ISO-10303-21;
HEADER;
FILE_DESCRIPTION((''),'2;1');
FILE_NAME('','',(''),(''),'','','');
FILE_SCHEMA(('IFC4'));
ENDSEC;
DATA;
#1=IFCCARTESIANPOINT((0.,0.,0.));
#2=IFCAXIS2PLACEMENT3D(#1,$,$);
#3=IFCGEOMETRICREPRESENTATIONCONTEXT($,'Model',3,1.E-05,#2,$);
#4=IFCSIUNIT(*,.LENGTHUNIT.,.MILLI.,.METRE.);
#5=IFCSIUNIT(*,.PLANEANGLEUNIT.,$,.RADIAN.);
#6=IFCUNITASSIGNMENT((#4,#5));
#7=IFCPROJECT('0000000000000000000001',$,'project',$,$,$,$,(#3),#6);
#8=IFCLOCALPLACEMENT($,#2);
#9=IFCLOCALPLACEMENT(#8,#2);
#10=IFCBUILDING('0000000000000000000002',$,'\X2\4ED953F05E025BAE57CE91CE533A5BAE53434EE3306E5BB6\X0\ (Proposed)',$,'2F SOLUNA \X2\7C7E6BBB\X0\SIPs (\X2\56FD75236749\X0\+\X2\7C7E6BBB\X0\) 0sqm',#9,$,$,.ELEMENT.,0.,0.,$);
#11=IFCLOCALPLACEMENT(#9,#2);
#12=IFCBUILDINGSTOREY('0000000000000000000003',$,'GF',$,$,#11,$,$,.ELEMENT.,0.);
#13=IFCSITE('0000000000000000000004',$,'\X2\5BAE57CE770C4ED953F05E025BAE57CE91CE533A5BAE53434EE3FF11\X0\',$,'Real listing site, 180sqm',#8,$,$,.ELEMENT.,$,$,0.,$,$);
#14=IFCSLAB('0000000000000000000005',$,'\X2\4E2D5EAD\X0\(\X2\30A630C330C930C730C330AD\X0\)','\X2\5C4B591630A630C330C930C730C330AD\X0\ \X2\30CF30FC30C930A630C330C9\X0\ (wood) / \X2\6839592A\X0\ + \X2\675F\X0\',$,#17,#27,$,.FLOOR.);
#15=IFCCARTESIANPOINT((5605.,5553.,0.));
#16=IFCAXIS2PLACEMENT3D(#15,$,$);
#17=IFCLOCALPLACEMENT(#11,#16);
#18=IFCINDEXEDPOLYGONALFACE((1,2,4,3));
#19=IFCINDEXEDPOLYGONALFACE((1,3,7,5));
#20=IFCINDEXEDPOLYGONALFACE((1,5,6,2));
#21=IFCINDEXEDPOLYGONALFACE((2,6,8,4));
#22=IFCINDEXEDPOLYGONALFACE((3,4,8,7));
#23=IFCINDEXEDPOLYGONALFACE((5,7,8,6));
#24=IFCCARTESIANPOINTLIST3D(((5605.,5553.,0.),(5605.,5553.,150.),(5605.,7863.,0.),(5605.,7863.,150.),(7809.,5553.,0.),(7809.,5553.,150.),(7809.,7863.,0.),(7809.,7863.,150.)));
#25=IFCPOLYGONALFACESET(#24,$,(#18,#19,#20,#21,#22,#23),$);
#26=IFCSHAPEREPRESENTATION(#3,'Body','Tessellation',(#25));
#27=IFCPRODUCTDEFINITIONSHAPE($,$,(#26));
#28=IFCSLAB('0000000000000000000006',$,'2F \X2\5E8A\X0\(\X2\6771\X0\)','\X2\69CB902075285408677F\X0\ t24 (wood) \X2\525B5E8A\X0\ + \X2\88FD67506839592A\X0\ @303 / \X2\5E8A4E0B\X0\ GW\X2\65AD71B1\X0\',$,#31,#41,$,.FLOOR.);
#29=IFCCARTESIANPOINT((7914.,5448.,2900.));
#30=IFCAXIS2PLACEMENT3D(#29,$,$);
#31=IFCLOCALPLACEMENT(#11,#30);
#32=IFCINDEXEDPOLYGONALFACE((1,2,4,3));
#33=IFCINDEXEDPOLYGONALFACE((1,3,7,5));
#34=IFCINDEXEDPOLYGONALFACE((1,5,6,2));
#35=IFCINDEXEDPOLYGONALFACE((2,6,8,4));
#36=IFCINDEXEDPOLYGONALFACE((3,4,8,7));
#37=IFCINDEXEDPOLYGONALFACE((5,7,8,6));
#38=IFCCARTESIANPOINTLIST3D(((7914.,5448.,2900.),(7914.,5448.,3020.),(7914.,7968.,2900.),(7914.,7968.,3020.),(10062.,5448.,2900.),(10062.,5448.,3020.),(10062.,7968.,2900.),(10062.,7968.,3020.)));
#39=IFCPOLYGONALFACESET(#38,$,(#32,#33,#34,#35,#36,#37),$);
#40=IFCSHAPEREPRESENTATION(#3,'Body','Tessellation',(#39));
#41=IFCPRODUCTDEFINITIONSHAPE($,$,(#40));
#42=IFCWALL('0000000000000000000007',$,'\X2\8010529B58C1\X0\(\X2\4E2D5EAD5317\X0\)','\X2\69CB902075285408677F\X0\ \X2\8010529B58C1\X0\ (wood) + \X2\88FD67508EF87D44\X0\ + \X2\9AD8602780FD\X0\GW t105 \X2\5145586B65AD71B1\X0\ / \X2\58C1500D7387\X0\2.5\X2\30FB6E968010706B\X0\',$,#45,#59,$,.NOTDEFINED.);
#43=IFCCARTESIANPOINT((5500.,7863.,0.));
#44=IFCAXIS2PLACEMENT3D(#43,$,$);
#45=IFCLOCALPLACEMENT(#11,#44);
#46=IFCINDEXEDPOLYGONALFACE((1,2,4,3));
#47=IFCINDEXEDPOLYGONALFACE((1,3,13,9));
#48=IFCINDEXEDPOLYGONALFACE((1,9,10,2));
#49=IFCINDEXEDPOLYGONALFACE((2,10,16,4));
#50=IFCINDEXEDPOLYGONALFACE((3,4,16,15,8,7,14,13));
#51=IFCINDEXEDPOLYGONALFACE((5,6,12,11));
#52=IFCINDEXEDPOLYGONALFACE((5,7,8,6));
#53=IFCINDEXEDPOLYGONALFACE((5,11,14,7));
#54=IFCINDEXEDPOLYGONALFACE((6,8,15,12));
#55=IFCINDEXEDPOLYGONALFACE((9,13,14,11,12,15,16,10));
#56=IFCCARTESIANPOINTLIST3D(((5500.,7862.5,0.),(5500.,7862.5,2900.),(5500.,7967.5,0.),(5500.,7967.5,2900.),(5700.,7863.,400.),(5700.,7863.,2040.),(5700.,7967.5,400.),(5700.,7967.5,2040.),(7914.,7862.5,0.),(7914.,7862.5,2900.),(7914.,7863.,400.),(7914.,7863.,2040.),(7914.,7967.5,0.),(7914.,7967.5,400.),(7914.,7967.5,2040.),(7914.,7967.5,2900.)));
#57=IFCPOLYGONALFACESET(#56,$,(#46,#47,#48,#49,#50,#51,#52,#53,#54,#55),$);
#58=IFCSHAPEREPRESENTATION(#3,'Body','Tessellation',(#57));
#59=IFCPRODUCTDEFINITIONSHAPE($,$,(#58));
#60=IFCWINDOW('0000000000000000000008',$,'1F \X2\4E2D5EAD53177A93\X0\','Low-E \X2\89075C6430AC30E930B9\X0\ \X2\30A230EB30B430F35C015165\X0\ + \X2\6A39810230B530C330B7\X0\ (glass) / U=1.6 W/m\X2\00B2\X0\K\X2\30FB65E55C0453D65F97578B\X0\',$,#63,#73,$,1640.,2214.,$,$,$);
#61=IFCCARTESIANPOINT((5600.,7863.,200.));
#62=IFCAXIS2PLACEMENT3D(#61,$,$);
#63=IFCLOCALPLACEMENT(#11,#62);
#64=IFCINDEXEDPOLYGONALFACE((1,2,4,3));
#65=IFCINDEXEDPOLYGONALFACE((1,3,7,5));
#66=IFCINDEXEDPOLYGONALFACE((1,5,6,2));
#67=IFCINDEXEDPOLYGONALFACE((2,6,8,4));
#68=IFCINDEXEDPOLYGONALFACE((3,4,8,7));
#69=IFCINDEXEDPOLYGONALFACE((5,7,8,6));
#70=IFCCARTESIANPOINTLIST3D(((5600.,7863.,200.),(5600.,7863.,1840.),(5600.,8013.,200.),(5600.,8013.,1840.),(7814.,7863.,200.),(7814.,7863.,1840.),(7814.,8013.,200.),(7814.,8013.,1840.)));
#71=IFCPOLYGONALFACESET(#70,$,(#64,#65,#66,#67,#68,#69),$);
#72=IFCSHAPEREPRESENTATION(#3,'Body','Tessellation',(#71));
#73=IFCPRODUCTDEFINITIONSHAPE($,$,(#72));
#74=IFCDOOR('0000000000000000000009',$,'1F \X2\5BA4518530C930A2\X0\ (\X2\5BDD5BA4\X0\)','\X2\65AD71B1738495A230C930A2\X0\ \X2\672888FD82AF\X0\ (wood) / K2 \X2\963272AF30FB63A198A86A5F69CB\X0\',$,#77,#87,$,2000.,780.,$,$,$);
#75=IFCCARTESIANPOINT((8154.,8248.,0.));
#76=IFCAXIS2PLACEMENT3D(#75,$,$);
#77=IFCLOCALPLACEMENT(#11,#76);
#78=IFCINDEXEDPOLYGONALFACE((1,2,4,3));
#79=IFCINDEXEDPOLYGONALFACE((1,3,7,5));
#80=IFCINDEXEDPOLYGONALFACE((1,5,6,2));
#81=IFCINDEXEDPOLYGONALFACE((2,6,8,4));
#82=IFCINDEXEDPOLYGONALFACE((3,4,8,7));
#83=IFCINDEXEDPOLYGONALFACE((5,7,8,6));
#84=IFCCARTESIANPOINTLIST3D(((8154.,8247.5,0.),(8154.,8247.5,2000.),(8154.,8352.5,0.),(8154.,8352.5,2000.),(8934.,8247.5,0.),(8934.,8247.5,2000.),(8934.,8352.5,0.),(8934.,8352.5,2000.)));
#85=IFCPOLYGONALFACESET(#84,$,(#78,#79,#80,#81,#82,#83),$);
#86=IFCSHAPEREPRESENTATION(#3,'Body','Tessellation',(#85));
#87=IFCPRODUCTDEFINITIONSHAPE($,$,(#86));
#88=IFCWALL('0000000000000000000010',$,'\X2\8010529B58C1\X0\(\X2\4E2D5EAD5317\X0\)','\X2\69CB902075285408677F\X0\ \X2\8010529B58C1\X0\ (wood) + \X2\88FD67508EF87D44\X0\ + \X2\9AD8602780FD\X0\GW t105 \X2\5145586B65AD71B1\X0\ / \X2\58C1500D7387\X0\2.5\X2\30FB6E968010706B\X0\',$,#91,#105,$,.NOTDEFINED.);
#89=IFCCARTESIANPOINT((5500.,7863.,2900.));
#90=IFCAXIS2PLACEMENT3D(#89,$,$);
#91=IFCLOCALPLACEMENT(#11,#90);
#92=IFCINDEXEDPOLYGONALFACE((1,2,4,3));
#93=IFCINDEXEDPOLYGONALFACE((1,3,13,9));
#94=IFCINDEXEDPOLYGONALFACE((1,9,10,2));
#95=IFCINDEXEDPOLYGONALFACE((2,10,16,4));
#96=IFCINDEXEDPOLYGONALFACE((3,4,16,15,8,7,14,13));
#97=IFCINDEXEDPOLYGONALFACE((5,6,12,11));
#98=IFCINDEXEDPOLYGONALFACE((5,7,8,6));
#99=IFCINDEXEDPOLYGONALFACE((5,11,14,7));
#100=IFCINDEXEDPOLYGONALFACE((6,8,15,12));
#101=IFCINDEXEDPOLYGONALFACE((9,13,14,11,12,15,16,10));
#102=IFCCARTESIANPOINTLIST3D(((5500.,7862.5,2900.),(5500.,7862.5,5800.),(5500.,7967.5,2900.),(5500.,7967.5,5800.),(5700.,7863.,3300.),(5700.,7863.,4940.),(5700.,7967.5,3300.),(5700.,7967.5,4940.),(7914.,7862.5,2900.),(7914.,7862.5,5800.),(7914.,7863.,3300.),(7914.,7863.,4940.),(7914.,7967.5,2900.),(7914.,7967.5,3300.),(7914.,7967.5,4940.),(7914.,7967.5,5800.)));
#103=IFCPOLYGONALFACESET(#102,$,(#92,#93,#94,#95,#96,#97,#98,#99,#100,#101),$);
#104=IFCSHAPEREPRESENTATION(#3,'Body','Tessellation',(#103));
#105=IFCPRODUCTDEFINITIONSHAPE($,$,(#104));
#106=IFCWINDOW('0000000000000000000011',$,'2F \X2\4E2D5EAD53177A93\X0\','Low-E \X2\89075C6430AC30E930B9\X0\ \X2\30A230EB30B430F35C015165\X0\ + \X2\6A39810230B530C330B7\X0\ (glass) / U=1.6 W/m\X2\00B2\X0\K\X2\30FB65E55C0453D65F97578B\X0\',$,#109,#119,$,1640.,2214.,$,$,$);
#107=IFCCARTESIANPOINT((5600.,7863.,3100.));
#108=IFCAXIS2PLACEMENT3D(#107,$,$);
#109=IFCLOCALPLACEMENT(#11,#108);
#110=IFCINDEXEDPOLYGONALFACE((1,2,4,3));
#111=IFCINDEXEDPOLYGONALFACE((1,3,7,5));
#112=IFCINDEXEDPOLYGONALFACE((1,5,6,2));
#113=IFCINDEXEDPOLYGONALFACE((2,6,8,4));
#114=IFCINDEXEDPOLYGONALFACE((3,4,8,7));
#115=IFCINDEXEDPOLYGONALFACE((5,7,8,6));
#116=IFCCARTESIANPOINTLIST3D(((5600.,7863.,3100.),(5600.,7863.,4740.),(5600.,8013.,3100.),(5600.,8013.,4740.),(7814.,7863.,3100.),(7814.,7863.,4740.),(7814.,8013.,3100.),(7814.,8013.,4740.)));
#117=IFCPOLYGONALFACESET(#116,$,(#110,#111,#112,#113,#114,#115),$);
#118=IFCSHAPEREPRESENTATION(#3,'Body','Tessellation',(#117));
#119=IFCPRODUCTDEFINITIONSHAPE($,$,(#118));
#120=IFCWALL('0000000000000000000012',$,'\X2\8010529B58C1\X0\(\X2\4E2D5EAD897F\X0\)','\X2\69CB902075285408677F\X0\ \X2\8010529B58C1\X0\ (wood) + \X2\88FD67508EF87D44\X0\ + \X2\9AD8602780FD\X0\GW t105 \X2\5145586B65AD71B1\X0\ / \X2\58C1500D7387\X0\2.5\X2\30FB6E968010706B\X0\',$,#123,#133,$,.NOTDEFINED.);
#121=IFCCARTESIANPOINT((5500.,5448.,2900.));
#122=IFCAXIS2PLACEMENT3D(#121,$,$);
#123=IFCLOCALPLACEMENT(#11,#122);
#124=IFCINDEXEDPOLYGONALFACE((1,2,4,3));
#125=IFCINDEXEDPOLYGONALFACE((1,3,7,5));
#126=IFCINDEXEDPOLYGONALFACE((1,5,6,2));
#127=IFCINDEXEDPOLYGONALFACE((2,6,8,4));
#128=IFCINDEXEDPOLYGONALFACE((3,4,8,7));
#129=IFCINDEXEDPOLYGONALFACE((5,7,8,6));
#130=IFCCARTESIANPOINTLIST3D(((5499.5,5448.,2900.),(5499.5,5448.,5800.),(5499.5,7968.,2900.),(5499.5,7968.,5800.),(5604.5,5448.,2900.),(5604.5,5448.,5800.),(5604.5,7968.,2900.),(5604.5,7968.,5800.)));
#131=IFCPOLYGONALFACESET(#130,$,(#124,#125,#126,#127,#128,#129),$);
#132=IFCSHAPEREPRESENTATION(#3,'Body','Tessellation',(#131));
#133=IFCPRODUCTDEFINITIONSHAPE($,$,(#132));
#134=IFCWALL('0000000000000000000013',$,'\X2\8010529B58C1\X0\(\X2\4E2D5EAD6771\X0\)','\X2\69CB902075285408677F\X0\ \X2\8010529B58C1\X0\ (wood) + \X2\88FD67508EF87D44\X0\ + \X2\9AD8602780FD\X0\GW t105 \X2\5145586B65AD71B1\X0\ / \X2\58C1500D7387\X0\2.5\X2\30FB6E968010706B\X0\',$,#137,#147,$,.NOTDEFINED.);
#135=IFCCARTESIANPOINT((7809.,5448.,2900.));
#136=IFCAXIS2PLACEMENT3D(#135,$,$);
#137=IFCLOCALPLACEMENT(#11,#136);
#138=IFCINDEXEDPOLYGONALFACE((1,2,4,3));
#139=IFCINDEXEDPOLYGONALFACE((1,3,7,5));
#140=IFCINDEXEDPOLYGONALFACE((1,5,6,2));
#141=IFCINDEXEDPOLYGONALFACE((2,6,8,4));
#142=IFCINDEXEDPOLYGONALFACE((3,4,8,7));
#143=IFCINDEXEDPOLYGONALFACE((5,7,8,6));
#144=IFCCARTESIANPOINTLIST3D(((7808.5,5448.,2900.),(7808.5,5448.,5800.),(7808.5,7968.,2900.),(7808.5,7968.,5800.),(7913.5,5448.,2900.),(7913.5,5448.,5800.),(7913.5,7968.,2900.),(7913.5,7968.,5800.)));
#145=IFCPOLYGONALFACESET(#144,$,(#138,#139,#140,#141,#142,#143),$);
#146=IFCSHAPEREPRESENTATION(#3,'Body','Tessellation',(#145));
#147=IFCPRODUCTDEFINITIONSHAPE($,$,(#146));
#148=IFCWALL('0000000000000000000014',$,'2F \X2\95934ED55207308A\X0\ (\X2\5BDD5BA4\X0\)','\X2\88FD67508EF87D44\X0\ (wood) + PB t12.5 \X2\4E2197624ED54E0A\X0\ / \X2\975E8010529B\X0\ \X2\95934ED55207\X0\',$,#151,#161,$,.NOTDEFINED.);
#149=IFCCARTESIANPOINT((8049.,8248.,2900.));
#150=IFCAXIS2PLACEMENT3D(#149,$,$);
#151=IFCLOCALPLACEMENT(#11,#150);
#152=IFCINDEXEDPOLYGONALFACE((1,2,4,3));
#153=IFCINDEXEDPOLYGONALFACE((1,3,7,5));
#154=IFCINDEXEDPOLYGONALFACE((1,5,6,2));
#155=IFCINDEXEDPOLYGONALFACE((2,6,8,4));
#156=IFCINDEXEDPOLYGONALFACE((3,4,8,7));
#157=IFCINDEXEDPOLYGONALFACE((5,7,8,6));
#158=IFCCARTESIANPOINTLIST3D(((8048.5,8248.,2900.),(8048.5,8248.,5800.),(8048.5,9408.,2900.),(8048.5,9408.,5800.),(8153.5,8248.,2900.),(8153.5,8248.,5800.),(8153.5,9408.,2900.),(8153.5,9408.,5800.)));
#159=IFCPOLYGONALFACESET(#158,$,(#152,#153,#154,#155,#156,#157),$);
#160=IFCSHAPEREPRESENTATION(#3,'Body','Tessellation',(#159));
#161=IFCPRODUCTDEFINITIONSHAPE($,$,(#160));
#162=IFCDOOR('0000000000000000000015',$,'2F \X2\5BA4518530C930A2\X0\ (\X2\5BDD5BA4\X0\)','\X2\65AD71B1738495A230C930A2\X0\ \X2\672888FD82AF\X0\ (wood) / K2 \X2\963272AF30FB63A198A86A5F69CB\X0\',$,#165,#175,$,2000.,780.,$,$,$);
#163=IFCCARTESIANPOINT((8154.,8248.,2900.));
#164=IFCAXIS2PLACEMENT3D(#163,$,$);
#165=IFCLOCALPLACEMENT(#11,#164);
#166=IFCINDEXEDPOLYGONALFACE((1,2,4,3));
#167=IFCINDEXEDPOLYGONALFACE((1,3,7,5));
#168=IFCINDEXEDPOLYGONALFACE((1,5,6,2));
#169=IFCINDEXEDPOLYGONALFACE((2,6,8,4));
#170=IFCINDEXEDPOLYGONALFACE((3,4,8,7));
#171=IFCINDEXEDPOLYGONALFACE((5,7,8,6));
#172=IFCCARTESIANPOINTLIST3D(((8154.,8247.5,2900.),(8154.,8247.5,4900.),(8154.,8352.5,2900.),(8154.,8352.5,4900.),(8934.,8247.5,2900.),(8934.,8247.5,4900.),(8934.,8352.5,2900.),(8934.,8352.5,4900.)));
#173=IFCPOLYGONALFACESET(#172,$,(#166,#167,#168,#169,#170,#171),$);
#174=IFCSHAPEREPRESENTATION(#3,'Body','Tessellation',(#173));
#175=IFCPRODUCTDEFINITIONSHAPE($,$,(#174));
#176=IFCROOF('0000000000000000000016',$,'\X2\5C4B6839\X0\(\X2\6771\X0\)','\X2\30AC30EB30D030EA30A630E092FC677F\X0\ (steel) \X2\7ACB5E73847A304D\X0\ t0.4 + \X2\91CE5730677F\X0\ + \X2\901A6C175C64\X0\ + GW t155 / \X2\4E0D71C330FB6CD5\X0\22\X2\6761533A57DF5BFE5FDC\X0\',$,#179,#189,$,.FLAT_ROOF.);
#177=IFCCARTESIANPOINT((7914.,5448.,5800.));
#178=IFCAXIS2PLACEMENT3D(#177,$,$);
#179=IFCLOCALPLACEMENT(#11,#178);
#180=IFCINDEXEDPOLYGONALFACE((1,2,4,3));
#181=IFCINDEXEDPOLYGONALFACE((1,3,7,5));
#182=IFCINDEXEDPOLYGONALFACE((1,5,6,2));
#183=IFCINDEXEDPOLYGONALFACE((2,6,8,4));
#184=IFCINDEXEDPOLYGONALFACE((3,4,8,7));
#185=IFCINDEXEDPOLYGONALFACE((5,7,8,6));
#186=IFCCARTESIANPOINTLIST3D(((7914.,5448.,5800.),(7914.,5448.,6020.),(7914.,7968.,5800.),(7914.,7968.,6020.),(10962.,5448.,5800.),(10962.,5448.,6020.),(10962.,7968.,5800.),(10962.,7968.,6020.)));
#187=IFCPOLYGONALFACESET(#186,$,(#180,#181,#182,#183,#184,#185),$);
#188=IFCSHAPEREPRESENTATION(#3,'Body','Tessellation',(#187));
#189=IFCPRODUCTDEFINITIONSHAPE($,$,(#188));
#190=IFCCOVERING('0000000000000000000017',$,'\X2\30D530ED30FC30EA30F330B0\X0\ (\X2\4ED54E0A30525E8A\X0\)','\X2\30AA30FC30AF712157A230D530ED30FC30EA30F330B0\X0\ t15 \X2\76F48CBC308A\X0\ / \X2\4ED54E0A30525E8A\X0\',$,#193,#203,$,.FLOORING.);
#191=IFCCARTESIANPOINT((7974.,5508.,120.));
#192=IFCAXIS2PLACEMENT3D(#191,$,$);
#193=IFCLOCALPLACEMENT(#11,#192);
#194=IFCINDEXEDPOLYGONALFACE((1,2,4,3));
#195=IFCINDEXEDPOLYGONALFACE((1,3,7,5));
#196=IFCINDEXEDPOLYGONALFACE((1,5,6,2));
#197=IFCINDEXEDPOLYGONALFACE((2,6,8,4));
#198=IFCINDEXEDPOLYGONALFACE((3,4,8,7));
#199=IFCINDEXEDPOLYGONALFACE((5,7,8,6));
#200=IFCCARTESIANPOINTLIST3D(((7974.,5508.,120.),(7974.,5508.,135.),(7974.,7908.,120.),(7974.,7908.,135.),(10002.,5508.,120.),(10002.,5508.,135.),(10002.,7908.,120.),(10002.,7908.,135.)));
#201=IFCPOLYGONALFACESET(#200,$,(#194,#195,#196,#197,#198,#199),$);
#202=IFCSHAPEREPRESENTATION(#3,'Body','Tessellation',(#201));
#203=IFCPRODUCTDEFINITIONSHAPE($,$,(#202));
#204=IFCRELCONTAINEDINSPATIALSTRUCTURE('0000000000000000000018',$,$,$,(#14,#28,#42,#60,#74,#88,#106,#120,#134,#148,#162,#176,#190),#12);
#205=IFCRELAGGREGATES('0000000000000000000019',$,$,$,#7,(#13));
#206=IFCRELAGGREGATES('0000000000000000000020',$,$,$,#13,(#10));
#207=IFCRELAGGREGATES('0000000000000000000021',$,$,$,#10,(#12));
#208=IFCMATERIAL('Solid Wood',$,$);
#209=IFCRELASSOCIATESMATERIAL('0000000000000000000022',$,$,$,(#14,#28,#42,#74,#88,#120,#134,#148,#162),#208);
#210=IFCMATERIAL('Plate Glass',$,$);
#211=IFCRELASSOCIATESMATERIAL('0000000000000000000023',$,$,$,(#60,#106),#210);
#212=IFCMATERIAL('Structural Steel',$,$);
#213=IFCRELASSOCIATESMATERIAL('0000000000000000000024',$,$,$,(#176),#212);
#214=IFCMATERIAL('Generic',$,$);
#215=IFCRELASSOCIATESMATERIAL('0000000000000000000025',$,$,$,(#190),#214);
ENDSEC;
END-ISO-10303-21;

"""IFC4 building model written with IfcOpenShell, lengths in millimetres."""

from ifc_helpers import new_model, si_unit, frame, frame_2d, origin, place, context, project, spatial, rectangle, extrude, material, element, fill, save


model = new_model("IFC4")

# Units and contexts
model_context = context("Model", 3, precision=1e-05, world=origin())
ifc_project = project(units=[si_unit("LENGTHUNIT", "METRE", prefix="MILLI"), si_unit("PLANEANGLEUNIT", "RADIAN")], contexts=[model_context])

# Site, building, storey
site_placement = place(None, origin())
site = spatial("IfcSite", under=ifc_project, at=site_placement, Name="宮城県仙台市宮城野区宮千代１", ObjectType="Real listing site, 180sqm", CompositionType="ELEMENT", RefElevation=0.0)
building_placement = place(site_placement, origin())
building = spatial("IfcBuilding", under=site, at=building_placement, Name="仙台市宮城野区宮千代の家 (Proposed)", ObjectType="2F SOLUNA 籾殻SIPs (国産杉+籾殻) 0sqm", CompositionType="ELEMENT", ElevationOfRefHeight=0.0, ElevationOfTerrain=0.0)
storey_placement = place(building_placement, origin())
storey = spatial("IfcBuildingStorey", under=building, at=storey_placement, Name="GF", CompositionType="ELEMENT", Elevation=0.0)

# Slabs
ifc_material_1 = material(Name="Solid Wood")
slab_1_placement = place(storey_placement, frame((5605.0, 5553.0, 0.0)))
element("IfcSlab", 1, at=slab_1_placement, inside=storey, material=ifc_material_1, Name="中庭(ウッドデッキ)", Description="屋外ウッドデッキ ハードウッド (wood) / 根太 + 束", PredefinedType="FLOOR", context=model_context, shape_type="SweptSolid", body=[
    extrude(rectangle(XDim=2204.0, YDim=2310.0, at=frame_2d((1102.0, 1155.0))), frame((5605.0, 5553.0, 0.0)), (0.0, 0.0, 1.0), 150.0),
])
slab_2_placement = place(storey_placement, frame((7914.0, 5448.0, 2900.0)))
element("IfcSlab", 2, at=slab_2_placement, inside=storey, material=ifc_material_1, Name="2F 床(東)", Description="構造用合板 t24 (wood) 剛床 + 製材根太 @303 / 床下 GW断熱", PredefinedType="FLOOR", context=model_context, shape_type="SweptSolid", body=[
    extrude(rectangle(XDim=2148.0, YDim=2520.0, at=frame_2d((1074.0, 1260.0))), frame((7914.0, 5448.0, 2900.0)), (0.0, 0.0, 1.0), 120.0),
])

# Wall, opening, window
wall_1_placement = place(storey_placement, frame((5500.0, 7863.0, 0.0)))
wall_1 = element("IfcWall", 3, at=wall_1_placement, inside=storey, material=ifc_material_1, Name="耐力壁(中庭北)", Description="構造用合板 耐力壁 (wood) + 製材軸組 + 高性能GW t105 充填断熱 / 壁倍率2.5・準耐火", PredefinedType="NOTDEFINED", context=model_context, shape_type="SweptSolid", body=[
    extrude(rectangle(XDim=2414.0, YDim=105.0, at=frame_2d((1207.0, 52.0))), frame((5500.0, 7863.0, 0.0)), (0.0, 0.0, 1.0), 2900.0),
])
opening_1_placement = place(storey_placement, frame((5600.0, 7863.0, 200.0)))
opening_1 = element("IfcOpeningElement", 4, at=opening_1_placement, cuts=wall_1, PredefinedType="NOTDEFINED", context=model_context, shape_type="SweptSolid", body=[
    extrude(rectangle(XDim=2214.0, YDim=150.0, at=frame_2d((1107.0, 75.0))), frame((5600.0, 7863.0, 200.0)), (0.0, 0.0, 1.0), 1640.0),
])
ifc_material_2 = material(Name="Plate Glass")
window_1_placement = place(storey_placement, frame((5600.0, 7863.0, 200.0)))
window_1 = element("IfcWindow", 5, at=window_1_placement, inside=storey, material=ifc_material_2, Name="1F 中庭北窓", Description="Low-E 複層ガラス アルゴン封入 + 樹脂サッシ (glass) / U=1.6 W/m²K・日射取得型", OverallHeight=1640.0, OverallWidth=2214.0, context=model_context, shape_type="SweptSolid", body=[
    extrude(rectangle(XDim=2214.0, YDim=150.0, at=frame_2d((1107.0, 75.0))), frame((5600.0, 7863.0, 200.0)), (0.0, 0.0, 1.0), 1640.0),
])
fill(opening_1, window_1)

# Door
door_1_placement = place(storey_placement, frame((8154.0, 8248.0, 0.0)))
element("IfcDoor", 6, at=door_1_placement, inside=storey, material=ifc_material_1, Name="1F 室内ドア (寝室)", Description="断熱玄関ドア 木製芯 (wood) / K2 防犯・採風機構", OverallHeight=2000.0, OverallWidth=780.0, context=model_context, shape_type="SweptSolid", body=[
    extrude(rectangle(XDim=780.0, YDim=105.0, at=frame_2d((390.0, 52.0))), frame((8154.0, 8248.0, 0.0)), (0.0, 0.0, 1.0), 2000.0),
])

# Wall, opening, window
wall_2_placement = place(storey_placement, frame((5500.0, 7863.0, 2900.0)))
wall_2 = element("IfcWall", 7, at=wall_2_placement, inside=storey, material=ifc_material_1, Name="耐力壁(中庭北)", Description="構造用合板 耐力壁 (wood) + 製材軸組 + 高性能GW t105 充填断熱 / 壁倍率2.5・準耐火", PredefinedType="NOTDEFINED", context=model_context, shape_type="SweptSolid", body=[
    extrude(rectangle(XDim=2414.0, YDim=105.0, at=frame_2d((1207.0, 52.0))), frame((5500.0, 7863.0, 2900.0)), (0.0, 0.0, 1.0), 2900.0),
])
opening_2_placement = place(storey_placement, frame((5600.0, 7863.0, 3100.0)))
opening_2 = element("IfcOpeningElement", 8, at=opening_2_placement, cuts=wall_2, PredefinedType="NOTDEFINED", context=model_context, shape_type="SweptSolid", body=[
    extrude(rectangle(XDim=2214.0, YDim=150.0, at=frame_2d((1107.0, 75.0))), frame((5600.0, 7863.0, 3100.0)), (0.0, 0.0, 1.0), 1640.0),
])
window_2_placement = place(storey_placement, frame((5600.0, 7863.0, 3100.0)))
window_2 = element("IfcWindow", 9, at=window_2_placement, inside=storey, material=ifc_material_2, Name="2F 中庭北窓", Description="Low-E 複層ガラス アルゴン封入 + 樹脂サッシ (glass) / U=1.6 W/m²K・日射取得型", OverallHeight=1640.0, OverallWidth=2214.0, context=model_context, shape_type="SweptSolid", body=[
    extrude(rectangle(XDim=2214.0, YDim=150.0, at=frame_2d((1107.0, 75.0))), frame((5600.0, 7863.0, 3100.0)), (0.0, 0.0, 1.0), 1640.0),
])
fill(opening_2, window_2)

# Walls
wall_3_placement = place(storey_placement, frame((5500.0, 5448.0, 2900.0)))
element("IfcWall", 10, at=wall_3_placement, inside=storey, material=ifc_material_1, Name="耐力壁(中庭西)", Description="構造用合板 耐力壁 (wood) + 製材軸組 + 高性能GW t105 充填断熱 / 壁倍率2.5・準耐火", PredefinedType="NOTDEFINED", context=model_context, shape_type="SweptSolid", body=[
    extrude(rectangle(XDim=105.0, YDim=2520.0, at=frame_2d((52.0, 1260.0))), frame((5500.0, 5448.0, 2900.0)), (0.0, 0.0, 1.0), 2900.0),
])
wall_4_placement = place(storey_placement, frame((7809.0, 5448.0, 2900.0)))
element("IfcWall", 11, at=wall_4_placement, inside=storey, material=ifc_material_1, Name="耐力壁(中庭東)", Description="構造用合板 耐力壁 (wood) + 製材軸組 + 高性能GW t105 充填断熱 / 壁倍率2.5・準耐火", PredefinedType="NOTDEFINED", context=model_context, shape_type="SweptSolid", body=[
    extrude(rectangle(XDim=105.0, YDim=2520.0, at=frame_2d((52.0, 1260.0))), frame((7809.0, 5448.0, 2900.0)), (0.0, 0.0, 1.0), 2900.0),
])
wall_5_placement = place(storey_placement, frame((8049.0, 8248.0, 2900.0)))
element("IfcWall", 12, at=wall_5_placement, inside=storey, material=ifc_material_1, Name="2F 間仕切り (寝室)", Description="製材軸組 (wood) + PB t12.5 両面仕上 / 非耐力 間仕切", PredefinedType="NOTDEFINED", context=model_context, shape_type="SweptSolid", body=[
    extrude(rectangle(XDim=105.0, YDim=1160.0, at=frame_2d((52.0, 580.0))), frame((8049.0, 8248.0, 2900.0)), (0.0, 0.0, 1.0), 2900.0),
])

# Door
door_2_placement = place(storey_placement, frame((8154.0, 8248.0, 2900.0)))
element("IfcDoor", 13, at=door_2_placement, inside=storey, material=ifc_material_1, Name="2F 室内ドア (寝室)", Description="断熱玄関ドア 木製芯 (wood) / K2 防犯・採風機構", OverallHeight=2000.0, OverallWidth=780.0, context=model_context, shape_type="SweptSolid", body=[
    extrude(rectangle(XDim=780.0, YDim=105.0, at=frame_2d((390.0, 52.0))), frame((8154.0, 8248.0, 2900.0)), (0.0, 0.0, 1.0), 2000.0),
])

# Roof
ifc_material_3 = material(Name="Structural Steel")
roof_placement = place(storey_placement, frame((7914.0, 5448.0, 5800.0)))
element("IfcRoof", 14, at=roof_placement, inside=storey, material=ifc_material_3, Name="屋根(東)", Description="ガルバリウム鋼板 (steel) 立平葺き t0.4 + 野地板 + 通気層 + GW t155 / 不燃・法22条区域対応", PredefinedType="FLAT_ROOF", context=model_context, shape_type="SweptSolid", body=[
    extrude(rectangle(XDim=3048.0, YDim=2520.0, at=frame_2d((1524.0, 1260.0))), frame((7914.0, 5448.0, 5800.0)), (0.0, 0.0, 1.0), 220.0),
])

# Covering
ifc_material_4 = material(Name="Generic")
covering_1_placement = place(storey_placement, frame((7974.0, 5508.0, 120.0)))
element("IfcCovering", 15, at=covering_1_placement, inside=storey, material=ifc_material_4, Name="フローリング (仕上げ床)", Description="オーク無垢フローリング t15 直貼り / 仕上げ床", PredefinedType="FLOORING", context=model_context, shape_type="SweptSolid", body=[
    extrude(rectangle(XDim=2028.0, YDim=2400.0, at=frame_2d((1014.0, 1200.0))), frame((7974.0, 5508.0, 120.0)), (0.0, 0.0, 1.0), 15.0),
])

save(model, "model.ifc")
